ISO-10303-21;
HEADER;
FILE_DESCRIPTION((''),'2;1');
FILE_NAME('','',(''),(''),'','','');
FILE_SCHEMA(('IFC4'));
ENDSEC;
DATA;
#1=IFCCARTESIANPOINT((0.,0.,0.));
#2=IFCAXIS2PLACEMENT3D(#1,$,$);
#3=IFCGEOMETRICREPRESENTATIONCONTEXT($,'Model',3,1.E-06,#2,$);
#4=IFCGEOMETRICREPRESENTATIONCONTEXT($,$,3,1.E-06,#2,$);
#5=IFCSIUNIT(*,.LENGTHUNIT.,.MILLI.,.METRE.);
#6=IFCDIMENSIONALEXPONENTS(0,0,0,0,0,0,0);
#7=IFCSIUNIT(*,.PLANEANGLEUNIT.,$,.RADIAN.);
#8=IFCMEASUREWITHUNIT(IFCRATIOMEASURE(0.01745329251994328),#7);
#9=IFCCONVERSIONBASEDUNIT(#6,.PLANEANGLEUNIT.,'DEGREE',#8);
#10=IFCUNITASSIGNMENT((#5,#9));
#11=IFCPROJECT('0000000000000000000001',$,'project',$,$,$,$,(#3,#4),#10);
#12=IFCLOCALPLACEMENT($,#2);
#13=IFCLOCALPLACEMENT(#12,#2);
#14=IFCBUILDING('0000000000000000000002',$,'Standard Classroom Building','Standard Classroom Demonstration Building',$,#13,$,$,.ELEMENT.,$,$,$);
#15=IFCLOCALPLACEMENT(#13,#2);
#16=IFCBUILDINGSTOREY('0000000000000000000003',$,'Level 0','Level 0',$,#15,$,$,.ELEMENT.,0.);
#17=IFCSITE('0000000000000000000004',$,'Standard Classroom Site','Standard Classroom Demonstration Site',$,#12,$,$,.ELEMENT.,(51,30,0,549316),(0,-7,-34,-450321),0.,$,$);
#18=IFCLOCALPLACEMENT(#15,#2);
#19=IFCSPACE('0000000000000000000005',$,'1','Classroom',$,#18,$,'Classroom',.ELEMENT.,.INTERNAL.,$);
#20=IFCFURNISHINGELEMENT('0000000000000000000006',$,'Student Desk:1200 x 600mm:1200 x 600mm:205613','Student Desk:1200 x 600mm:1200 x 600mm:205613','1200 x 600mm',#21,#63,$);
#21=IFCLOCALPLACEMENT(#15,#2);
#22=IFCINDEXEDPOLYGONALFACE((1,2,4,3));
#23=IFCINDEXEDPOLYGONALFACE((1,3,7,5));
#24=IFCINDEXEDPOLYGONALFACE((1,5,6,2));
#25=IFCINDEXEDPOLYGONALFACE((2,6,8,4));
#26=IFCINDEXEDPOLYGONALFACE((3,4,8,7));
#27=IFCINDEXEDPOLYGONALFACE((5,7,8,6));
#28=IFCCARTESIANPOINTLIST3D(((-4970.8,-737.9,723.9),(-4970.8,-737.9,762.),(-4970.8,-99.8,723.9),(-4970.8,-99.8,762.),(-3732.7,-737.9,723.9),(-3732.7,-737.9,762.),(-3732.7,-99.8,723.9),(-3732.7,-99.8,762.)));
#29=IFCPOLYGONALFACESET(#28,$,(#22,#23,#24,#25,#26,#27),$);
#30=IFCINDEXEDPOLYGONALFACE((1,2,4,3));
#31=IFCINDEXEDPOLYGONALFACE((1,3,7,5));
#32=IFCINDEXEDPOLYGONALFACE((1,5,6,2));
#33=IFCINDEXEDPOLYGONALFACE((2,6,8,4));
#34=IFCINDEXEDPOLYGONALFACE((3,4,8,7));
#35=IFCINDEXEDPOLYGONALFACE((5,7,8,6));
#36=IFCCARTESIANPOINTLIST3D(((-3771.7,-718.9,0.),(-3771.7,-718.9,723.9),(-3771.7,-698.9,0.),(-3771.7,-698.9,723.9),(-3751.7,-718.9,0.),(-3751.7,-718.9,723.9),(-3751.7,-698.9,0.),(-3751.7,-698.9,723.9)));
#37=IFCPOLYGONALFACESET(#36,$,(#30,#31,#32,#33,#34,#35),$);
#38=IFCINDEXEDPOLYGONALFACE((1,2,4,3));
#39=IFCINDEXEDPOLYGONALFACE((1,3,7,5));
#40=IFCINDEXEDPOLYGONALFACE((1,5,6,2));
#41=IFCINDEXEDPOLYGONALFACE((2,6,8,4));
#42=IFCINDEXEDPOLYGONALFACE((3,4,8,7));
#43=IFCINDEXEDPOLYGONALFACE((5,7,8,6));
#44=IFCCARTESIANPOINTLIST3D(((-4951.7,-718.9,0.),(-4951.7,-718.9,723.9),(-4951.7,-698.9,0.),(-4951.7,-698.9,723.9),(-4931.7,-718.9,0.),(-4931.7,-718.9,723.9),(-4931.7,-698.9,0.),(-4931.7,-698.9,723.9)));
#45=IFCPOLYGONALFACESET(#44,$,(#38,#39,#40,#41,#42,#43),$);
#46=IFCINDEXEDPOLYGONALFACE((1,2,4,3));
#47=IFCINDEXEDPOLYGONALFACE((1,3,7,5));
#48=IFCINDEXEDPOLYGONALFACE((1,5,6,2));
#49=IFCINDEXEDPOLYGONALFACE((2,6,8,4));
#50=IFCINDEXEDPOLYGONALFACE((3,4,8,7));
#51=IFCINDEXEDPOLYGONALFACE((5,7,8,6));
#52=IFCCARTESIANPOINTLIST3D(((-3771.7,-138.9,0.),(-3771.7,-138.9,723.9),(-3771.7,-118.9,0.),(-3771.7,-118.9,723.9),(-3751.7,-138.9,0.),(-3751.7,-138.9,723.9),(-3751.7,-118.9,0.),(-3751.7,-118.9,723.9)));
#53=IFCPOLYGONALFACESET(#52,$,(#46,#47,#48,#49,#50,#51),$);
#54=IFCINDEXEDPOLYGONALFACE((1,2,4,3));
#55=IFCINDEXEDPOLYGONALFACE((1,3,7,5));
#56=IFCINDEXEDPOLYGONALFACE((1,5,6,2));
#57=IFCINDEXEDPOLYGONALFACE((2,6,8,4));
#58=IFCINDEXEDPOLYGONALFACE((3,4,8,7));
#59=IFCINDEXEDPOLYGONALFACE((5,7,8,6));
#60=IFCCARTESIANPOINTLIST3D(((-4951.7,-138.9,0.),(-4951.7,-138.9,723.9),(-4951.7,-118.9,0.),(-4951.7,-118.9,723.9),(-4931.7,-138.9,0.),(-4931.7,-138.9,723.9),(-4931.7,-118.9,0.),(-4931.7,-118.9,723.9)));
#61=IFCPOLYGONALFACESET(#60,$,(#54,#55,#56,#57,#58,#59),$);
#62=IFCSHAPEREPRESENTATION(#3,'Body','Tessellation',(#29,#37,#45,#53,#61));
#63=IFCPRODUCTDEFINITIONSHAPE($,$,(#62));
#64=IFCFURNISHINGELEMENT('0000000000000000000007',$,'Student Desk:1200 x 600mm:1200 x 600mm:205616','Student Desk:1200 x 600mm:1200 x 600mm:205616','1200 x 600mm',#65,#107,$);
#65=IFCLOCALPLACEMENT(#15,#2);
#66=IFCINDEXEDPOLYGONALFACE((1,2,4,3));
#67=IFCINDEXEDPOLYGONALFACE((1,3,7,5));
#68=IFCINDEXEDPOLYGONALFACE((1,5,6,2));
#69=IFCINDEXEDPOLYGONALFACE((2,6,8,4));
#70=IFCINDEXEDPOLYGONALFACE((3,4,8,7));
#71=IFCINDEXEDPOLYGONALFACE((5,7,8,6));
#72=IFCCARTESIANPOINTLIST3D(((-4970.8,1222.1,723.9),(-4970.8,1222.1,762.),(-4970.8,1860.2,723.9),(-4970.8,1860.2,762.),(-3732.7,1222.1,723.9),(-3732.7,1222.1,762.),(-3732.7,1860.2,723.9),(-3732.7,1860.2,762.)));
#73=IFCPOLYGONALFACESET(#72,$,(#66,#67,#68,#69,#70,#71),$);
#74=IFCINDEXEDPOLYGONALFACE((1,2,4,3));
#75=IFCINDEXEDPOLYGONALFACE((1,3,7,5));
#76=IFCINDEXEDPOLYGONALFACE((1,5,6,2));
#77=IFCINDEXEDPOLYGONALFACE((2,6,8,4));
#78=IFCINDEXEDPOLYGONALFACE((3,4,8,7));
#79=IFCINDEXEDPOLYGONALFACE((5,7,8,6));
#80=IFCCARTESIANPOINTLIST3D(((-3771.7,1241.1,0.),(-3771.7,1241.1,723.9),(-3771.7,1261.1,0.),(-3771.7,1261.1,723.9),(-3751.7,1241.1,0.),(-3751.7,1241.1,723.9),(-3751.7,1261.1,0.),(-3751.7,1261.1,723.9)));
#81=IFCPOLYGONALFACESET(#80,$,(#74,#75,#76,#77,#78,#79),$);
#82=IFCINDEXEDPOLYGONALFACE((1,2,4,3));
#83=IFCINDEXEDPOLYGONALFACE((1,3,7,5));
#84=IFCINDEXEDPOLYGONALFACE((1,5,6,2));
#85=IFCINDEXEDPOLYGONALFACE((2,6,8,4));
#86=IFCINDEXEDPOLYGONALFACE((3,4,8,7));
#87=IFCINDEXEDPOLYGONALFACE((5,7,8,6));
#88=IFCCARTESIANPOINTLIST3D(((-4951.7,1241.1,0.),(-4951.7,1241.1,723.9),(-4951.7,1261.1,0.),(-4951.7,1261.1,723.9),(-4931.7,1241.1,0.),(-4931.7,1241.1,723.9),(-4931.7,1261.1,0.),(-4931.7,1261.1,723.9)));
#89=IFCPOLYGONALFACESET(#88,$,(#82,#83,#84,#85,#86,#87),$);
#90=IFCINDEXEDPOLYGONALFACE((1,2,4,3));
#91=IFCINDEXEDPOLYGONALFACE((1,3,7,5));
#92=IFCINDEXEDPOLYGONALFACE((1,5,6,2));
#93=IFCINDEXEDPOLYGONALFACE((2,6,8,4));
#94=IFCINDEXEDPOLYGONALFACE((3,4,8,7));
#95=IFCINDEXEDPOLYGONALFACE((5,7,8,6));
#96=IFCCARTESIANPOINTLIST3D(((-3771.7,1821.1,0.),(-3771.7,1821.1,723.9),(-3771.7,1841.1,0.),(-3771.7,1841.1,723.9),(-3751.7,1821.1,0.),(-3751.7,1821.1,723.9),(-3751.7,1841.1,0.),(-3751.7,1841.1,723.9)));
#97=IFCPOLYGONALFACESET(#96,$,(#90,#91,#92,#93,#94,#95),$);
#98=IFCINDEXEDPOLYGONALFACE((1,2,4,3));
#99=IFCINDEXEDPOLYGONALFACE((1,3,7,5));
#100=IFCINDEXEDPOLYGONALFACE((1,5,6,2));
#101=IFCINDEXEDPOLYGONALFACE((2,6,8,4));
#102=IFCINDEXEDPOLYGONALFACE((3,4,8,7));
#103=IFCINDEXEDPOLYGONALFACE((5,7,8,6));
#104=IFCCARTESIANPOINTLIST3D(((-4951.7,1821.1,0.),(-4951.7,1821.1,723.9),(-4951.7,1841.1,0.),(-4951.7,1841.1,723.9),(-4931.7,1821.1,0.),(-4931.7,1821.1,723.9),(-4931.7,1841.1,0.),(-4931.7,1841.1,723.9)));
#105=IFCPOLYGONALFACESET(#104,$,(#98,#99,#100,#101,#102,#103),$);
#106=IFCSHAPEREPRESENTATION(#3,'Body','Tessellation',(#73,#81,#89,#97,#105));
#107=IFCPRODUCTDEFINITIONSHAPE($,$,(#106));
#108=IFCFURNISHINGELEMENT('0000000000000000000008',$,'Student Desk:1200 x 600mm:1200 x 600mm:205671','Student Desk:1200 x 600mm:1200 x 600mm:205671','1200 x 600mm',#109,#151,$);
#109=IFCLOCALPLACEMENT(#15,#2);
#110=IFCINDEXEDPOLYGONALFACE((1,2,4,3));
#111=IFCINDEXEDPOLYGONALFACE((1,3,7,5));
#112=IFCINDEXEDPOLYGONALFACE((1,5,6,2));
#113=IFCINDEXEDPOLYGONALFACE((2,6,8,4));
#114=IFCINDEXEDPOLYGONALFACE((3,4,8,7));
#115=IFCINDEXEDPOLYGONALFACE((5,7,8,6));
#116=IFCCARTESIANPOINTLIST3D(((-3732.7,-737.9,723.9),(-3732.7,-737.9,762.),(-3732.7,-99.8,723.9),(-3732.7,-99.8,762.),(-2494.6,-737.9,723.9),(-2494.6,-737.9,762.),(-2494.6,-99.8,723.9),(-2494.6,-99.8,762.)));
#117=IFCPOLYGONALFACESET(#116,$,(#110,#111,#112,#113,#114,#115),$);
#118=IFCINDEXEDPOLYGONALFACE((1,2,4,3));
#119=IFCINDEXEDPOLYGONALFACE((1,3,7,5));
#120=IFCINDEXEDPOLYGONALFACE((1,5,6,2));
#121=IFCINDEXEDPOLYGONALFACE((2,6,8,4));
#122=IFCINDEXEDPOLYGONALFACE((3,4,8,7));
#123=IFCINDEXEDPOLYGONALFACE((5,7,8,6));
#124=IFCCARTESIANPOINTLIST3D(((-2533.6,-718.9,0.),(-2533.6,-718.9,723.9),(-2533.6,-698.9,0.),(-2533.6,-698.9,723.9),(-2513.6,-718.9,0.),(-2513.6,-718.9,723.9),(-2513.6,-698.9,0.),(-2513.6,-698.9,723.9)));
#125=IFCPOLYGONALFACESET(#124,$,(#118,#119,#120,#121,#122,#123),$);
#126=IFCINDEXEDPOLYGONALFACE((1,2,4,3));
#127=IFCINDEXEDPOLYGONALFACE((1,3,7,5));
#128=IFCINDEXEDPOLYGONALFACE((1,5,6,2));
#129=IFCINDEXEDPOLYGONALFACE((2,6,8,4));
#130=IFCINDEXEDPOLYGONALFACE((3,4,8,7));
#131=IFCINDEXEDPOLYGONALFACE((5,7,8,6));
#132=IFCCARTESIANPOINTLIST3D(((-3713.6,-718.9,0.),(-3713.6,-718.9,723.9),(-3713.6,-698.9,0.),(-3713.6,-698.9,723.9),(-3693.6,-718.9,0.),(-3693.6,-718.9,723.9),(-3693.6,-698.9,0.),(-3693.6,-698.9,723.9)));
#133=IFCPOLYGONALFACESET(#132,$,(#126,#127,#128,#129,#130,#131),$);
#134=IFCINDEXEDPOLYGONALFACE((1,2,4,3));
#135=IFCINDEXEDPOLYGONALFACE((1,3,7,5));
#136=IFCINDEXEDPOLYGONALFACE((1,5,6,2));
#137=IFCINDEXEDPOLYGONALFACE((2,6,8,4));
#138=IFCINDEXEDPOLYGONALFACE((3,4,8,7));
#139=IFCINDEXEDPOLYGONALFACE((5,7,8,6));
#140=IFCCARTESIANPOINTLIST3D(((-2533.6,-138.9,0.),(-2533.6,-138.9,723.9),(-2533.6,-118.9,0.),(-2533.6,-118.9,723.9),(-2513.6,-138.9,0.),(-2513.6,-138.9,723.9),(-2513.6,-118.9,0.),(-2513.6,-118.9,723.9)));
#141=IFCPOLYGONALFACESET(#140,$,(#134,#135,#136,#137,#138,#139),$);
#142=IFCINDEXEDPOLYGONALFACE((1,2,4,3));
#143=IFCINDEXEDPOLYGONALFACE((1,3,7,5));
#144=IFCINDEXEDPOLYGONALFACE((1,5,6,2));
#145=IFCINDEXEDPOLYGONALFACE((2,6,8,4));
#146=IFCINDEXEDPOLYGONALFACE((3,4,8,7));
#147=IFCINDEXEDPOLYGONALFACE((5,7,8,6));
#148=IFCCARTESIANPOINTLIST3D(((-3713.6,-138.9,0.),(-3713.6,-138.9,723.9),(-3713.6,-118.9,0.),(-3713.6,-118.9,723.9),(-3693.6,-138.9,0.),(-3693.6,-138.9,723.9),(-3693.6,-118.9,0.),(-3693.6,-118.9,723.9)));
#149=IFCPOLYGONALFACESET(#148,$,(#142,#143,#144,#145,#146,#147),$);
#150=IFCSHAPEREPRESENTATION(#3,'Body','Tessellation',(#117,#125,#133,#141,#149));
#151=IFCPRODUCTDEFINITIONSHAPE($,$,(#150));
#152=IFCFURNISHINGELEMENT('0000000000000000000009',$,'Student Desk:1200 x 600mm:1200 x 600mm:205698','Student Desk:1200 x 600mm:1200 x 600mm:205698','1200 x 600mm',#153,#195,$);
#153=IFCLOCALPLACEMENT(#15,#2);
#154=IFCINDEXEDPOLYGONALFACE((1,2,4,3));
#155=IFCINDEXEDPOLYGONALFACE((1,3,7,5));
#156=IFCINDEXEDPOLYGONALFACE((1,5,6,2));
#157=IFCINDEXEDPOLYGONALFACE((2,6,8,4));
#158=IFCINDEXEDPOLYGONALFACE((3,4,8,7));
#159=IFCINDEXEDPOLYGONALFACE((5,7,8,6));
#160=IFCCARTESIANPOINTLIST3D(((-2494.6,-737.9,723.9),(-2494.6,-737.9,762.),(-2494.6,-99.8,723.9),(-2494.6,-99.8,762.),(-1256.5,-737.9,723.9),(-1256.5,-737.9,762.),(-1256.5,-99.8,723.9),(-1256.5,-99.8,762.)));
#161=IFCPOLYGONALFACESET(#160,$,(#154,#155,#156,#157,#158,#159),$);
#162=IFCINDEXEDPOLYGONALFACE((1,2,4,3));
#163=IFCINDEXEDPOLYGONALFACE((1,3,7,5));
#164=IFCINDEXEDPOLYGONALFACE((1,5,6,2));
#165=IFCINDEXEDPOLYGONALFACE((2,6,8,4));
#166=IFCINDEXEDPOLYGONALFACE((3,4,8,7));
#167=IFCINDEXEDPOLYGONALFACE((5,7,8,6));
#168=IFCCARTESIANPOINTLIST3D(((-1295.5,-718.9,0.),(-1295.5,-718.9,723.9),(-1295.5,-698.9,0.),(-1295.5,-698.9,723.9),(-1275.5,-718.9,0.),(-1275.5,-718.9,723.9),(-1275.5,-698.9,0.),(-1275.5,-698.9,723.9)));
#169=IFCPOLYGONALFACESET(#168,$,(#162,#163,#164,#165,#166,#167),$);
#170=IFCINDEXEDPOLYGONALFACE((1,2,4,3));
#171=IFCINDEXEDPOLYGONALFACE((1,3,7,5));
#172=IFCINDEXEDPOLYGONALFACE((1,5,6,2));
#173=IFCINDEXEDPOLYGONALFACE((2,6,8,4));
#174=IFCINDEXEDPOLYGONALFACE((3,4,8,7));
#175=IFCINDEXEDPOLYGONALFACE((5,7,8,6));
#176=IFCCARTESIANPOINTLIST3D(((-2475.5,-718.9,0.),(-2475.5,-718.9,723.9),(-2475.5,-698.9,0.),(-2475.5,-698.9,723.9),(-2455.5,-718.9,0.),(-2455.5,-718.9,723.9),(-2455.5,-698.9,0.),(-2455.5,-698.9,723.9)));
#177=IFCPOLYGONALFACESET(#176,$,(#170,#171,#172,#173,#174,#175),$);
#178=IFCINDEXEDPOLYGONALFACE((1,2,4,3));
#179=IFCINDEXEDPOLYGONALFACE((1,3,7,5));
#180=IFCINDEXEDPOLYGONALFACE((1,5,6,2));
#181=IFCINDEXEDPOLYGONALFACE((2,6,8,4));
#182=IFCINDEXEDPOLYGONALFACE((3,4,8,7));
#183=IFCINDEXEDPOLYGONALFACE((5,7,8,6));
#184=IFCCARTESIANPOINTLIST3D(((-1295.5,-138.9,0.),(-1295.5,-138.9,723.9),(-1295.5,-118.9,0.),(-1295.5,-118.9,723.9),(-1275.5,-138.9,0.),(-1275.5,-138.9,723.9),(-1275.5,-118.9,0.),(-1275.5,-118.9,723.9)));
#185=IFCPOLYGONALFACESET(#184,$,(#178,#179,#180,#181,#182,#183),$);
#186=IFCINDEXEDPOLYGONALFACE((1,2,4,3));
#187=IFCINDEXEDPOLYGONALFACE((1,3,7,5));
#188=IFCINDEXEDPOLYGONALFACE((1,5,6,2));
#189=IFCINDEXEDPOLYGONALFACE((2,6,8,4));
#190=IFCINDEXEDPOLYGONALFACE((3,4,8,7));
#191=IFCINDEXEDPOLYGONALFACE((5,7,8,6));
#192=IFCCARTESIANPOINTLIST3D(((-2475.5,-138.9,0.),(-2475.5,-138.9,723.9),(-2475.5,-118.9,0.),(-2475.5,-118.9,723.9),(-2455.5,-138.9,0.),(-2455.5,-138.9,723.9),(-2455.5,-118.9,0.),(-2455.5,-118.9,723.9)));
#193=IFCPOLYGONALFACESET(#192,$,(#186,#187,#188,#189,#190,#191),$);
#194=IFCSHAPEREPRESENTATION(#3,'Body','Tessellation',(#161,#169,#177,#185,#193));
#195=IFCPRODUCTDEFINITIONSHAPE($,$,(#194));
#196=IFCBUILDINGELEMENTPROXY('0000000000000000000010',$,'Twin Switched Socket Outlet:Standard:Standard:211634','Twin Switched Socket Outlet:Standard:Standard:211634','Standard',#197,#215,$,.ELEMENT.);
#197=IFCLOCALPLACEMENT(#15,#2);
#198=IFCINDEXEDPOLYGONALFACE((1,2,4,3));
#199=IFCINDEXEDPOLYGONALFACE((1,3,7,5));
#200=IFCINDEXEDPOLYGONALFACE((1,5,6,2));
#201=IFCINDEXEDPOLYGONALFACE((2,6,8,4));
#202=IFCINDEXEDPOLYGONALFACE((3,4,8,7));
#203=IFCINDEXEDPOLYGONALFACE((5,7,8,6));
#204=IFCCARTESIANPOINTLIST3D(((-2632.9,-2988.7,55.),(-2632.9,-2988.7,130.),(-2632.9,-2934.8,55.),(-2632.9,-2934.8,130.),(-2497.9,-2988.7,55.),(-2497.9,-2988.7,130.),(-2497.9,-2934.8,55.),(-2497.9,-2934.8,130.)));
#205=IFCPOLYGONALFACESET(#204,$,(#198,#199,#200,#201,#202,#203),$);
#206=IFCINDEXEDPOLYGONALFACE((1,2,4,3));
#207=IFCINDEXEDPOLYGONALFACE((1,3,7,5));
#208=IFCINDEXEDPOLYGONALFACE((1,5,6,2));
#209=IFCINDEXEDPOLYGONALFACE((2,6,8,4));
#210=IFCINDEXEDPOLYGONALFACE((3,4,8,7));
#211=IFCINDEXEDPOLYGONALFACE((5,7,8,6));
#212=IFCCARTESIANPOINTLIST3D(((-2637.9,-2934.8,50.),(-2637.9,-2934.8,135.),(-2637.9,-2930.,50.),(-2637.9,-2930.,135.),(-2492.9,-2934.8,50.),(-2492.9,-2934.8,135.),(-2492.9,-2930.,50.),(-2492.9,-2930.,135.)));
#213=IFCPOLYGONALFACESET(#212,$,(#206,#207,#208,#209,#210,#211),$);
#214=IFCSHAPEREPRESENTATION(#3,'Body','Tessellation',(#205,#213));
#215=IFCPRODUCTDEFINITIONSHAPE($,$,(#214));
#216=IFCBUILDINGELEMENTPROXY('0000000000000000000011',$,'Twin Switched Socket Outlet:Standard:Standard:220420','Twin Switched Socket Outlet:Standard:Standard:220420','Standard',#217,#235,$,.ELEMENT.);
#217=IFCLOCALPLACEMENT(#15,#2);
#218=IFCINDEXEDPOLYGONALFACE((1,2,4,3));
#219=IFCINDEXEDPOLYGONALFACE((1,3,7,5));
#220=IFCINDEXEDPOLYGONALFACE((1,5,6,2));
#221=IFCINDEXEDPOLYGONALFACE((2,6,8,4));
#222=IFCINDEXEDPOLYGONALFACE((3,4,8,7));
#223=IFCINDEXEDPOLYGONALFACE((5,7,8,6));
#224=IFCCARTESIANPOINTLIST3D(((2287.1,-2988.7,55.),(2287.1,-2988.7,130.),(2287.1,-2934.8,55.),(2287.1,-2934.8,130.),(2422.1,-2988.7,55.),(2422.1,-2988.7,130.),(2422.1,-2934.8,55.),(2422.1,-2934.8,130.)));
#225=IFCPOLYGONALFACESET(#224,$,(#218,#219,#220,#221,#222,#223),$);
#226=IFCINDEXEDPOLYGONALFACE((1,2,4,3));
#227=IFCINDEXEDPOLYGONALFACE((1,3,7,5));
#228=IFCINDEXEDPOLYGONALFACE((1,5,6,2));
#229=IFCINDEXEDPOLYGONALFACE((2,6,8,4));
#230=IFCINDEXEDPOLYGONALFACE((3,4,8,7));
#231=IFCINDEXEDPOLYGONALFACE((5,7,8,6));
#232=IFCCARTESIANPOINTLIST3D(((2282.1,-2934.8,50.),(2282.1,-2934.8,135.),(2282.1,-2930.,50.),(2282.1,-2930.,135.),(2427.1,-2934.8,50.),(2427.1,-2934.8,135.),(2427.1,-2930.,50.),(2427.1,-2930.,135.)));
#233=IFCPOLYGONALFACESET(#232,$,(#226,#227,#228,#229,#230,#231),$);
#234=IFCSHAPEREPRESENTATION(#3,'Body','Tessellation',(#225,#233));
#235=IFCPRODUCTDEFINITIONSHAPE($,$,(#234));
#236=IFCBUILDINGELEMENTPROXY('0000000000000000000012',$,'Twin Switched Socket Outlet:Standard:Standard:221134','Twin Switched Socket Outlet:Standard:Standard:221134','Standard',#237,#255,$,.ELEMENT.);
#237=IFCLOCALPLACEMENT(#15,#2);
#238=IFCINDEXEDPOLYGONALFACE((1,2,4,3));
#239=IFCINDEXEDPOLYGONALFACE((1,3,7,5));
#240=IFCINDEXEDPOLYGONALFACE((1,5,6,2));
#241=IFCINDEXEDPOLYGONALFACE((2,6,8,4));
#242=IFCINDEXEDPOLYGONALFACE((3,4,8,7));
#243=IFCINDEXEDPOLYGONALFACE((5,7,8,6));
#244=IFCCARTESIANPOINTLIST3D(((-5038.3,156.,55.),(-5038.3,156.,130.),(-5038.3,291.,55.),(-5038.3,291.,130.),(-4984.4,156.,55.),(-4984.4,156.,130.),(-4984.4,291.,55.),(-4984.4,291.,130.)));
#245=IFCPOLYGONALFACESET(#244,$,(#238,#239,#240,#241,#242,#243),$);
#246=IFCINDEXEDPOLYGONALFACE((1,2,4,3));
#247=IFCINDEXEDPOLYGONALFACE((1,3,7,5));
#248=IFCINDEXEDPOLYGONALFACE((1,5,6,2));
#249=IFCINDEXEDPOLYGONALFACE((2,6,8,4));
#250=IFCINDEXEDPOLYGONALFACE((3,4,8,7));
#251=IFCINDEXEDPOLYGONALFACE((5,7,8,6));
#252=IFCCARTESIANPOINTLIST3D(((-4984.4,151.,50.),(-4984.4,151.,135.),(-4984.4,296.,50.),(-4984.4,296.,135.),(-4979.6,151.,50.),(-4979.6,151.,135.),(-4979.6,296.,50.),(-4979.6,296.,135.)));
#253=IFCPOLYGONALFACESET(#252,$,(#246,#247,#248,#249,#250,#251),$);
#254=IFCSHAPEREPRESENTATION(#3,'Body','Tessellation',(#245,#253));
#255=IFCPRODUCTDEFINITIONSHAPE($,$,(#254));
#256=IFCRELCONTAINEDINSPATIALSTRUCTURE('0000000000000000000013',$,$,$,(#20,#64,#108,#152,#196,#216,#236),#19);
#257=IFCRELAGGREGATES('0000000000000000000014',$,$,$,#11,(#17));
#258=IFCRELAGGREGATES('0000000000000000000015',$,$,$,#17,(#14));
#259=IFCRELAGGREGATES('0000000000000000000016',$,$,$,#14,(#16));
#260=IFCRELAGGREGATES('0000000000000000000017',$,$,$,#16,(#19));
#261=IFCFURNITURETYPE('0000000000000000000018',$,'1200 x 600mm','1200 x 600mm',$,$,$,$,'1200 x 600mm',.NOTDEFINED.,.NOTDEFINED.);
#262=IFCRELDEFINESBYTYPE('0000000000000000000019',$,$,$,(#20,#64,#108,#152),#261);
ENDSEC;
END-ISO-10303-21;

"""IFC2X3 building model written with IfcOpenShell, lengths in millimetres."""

from ifc_helpers import new_model, entity, si_unit, converted_unit, frame, origin, origin_2d_with_axis, place, context, project, spatial, rectangle, extrude, source, transform, mapped, type_object, type_shapes, element, save


model = new_model("IFC2X3")

# Units and contexts
model_context = context("Model", 3, precision=1e-06, world=origin())
context_of_model = context(None, 3, precision=1e-06, world=origin())
ifc_project = project(units=[si_unit("LENGTHUNIT", "METRE", prefix="MILLI"), converted_unit("PLANEANGLEUNIT", "DEGREE", entity("IfcRatioMeasure", 0.01745329251994328), si_unit("PLANEANGLEUNIT", "RADIAN"), dimensions=[0, 0, 0, 0, 0, 0, 0])], contexts=[model_context, context_of_model])

# Site, building, storey
site_placement = place(None, origin())
site = spatial("IfcSite", under=ifc_project, at=site_placement, Name="Standard Classroom Site", Description="Standard Classroom Demonstration Site", CompositionType="ELEMENT", RefLatitude=(51, 30, 0, 549316), RefLongitude=(0, -7, -34, -450321), RefElevation=0.0)
building_placement = place(site_placement, origin())
building = spatial("IfcBuilding", under=site, at=building_placement, Name="Standard Classroom Building", Description="Standard Classroom Demonstration Building", CompositionType="ELEMENT")
storey_placement = place(building_placement, origin())
storey = spatial("IfcBuildingStorey", under=building, at=storey_placement, Name="Level 0", Description="Level 0", CompositionType="ELEMENT", Elevation=0.0)

# Shared definitions
space_placement = place(storey_placement, origin())
space = spatial("IfcSpace", under=storey, at=space_placement, Name="1", Description="Classroom", LongName="Classroom", CompositionType="ELEMENT", InteriorOrExteriorSpace="INTERNAL")

# Furnishing elements
furniture_type = type_object("IfcFurnitureType", Name="1200 x 600mm", Description="1200 x 600mm", ElementType="1200 x 600mm", AssemblyPlace="NOTDEFINED")
shared_shape_1 = source(origin(), model_context, "Body", "SweptSolid", [
    extrude(rectangle(XDim=1238.1, YDim=638.1, at=origin_2d_with_axis()), frame((600.0, 300.0, 723.9), z_axis=(0.0, 0.0, 1.0), x_axis=(-1.0, 0.0, 0.0)), (0.0, 0.0, 1.0), 38.1),
    extrude(rectangle(XDim=20.0, YDim=20.0, at=origin_2d_with_axis()), frame((1190.0, 10.0, 0.0)), (0.0, 0.0, 1.0), 723.9),
    extrude(rectangle(XDim=20.0, YDim=20.0, at=origin_2d_with_axis()), frame((10.0, 10.0, 0.0), z_axis=(0.0, 0.0, 1.0), x_axis=(0.0, 1.0, 0.0)), (0.0, 0.0, 1.0), 723.9),
    extrude(rectangle(XDim=20.0, YDim=20.0, at=origin_2d_with_axis()), frame((1190.0, 590.0, 0.0), z_axis=(0.0, 0.0, 1.0), x_axis=(0.0, -1.0, 0.0)), (0.0, 0.0, 1.0), 723.9),
    extrude(rectangle(XDim=20.0, YDim=20.0, at=origin_2d_with_axis()), frame((10.0, 590.0, 0.0), z_axis=(0.0, 0.0, 1.0), x_axis=(-1.0, 0.0, 0.0)), (0.0, 0.0, 1.0), 723.9),
])
type_shapes(furniture_type, [shared_shape_1])
for number, where, name, description in (
    (1, (-4951.7, -718.9, 0.0), "Student Desk:1200 x 600mm:1200 x 600mm:205613", "Student Desk:1200 x 600mm:1200 x 600mm:205613"),
    (2, (-4951.7, 1241.1, 0.0), "Student Desk:1200 x 600mm:1200 x 600mm:205616", "Student Desk:1200 x 600mm:1200 x 600mm:205616"),
    (3, (-3713.6, -718.9, 0.0), "Student Desk:1200 x 600mm:1200 x 600mm:205671", "Student Desk:1200 x 600mm:1200 x 600mm:205671"),
    (4, (-2475.5, -718.9, 0.0), "Student Desk:1200 x 600mm:1200 x 600mm:205698", "Student Desk:1200 x 600mm:1200 x 600mm:205698"),
):
    element("IfcFurnishingElement", number, at=place(space_placement, frame(where)), inside=space, type_object=furniture_type, Name=name, Description=description, ObjectType="1200 x 600mm", context=model_context, shape_type="MappedRepresentation", body=[
        mapped(shared_shape_1, transform((0.0, 0.0, 0.0), scale=1.0)),
    ])

# Building element proxies
shared_shape_2 = source(origin(), model_context, "Body", "SweptSolid", [
    extrude(rectangle(XDim=135.0, YDim=75.0, at=origin_2d_with_axis()), frame((0.0, 0.0, -54.0), z_axis=(0.0, 0.0, 1.0), x_axis=(-1.0, 0.0, 0.0)), (0.0, 0.0, 1.0), 54.0),
    extrude(rectangle(XDim=145.0, YDim=85.0, at=origin_2d_with_axis()), frame((0.0, 0.0, 0.0), z_axis=(0.0, 0.0, 1.0), x_axis=(-1.0, 0.0, 0.0)), (0.0, 0.0, 1.0), 4.8),
])
for number, where, z_axis, x_axis, name, description in (
    (5, (-2565.4, -2934.8, 92.5), (0.0, 1.0, 0.0), (-1.0, 0.0, 0.0), "Twin Switched Socket Outlet:Standard:Standard:211634", "Twin Switched Socket Outlet:Standard:Standard:211634"),
    (6, (2354.6, -2934.8, 92.5), (0.0, 1.0, 0.0), (-1.0, 0.0, 0.0), "Twin Switched Socket Outlet:Standard:Standard:220420", "Twin Switched Socket Outlet:Standard:Standard:220420"),
    (7, (-4984.4, 223.5, 92.5), (1.0, 0.0, 0.0), (0.0, 1.0, 0.0), "Twin Switched Socket Outlet:Standard:Standard:221134", "Twin Switched Socket Outlet:Standard:Standard:221134"),
):
    element("IfcBuildingElementProxy", number, at=place(space_placement, frame(where, z_axis=z_axis, x_axis=x_axis)), inside=space, Name=name, Description=description, ObjectType="Standard", CompositionType="ELEMENT", context=model_context, shape_type="MappedRepresentation", body=[
        mapped(shared_shape_2, transform((0.0, 0.0, 0.0), scale=1.0)),
    ])

save(model, "model.ifc")
